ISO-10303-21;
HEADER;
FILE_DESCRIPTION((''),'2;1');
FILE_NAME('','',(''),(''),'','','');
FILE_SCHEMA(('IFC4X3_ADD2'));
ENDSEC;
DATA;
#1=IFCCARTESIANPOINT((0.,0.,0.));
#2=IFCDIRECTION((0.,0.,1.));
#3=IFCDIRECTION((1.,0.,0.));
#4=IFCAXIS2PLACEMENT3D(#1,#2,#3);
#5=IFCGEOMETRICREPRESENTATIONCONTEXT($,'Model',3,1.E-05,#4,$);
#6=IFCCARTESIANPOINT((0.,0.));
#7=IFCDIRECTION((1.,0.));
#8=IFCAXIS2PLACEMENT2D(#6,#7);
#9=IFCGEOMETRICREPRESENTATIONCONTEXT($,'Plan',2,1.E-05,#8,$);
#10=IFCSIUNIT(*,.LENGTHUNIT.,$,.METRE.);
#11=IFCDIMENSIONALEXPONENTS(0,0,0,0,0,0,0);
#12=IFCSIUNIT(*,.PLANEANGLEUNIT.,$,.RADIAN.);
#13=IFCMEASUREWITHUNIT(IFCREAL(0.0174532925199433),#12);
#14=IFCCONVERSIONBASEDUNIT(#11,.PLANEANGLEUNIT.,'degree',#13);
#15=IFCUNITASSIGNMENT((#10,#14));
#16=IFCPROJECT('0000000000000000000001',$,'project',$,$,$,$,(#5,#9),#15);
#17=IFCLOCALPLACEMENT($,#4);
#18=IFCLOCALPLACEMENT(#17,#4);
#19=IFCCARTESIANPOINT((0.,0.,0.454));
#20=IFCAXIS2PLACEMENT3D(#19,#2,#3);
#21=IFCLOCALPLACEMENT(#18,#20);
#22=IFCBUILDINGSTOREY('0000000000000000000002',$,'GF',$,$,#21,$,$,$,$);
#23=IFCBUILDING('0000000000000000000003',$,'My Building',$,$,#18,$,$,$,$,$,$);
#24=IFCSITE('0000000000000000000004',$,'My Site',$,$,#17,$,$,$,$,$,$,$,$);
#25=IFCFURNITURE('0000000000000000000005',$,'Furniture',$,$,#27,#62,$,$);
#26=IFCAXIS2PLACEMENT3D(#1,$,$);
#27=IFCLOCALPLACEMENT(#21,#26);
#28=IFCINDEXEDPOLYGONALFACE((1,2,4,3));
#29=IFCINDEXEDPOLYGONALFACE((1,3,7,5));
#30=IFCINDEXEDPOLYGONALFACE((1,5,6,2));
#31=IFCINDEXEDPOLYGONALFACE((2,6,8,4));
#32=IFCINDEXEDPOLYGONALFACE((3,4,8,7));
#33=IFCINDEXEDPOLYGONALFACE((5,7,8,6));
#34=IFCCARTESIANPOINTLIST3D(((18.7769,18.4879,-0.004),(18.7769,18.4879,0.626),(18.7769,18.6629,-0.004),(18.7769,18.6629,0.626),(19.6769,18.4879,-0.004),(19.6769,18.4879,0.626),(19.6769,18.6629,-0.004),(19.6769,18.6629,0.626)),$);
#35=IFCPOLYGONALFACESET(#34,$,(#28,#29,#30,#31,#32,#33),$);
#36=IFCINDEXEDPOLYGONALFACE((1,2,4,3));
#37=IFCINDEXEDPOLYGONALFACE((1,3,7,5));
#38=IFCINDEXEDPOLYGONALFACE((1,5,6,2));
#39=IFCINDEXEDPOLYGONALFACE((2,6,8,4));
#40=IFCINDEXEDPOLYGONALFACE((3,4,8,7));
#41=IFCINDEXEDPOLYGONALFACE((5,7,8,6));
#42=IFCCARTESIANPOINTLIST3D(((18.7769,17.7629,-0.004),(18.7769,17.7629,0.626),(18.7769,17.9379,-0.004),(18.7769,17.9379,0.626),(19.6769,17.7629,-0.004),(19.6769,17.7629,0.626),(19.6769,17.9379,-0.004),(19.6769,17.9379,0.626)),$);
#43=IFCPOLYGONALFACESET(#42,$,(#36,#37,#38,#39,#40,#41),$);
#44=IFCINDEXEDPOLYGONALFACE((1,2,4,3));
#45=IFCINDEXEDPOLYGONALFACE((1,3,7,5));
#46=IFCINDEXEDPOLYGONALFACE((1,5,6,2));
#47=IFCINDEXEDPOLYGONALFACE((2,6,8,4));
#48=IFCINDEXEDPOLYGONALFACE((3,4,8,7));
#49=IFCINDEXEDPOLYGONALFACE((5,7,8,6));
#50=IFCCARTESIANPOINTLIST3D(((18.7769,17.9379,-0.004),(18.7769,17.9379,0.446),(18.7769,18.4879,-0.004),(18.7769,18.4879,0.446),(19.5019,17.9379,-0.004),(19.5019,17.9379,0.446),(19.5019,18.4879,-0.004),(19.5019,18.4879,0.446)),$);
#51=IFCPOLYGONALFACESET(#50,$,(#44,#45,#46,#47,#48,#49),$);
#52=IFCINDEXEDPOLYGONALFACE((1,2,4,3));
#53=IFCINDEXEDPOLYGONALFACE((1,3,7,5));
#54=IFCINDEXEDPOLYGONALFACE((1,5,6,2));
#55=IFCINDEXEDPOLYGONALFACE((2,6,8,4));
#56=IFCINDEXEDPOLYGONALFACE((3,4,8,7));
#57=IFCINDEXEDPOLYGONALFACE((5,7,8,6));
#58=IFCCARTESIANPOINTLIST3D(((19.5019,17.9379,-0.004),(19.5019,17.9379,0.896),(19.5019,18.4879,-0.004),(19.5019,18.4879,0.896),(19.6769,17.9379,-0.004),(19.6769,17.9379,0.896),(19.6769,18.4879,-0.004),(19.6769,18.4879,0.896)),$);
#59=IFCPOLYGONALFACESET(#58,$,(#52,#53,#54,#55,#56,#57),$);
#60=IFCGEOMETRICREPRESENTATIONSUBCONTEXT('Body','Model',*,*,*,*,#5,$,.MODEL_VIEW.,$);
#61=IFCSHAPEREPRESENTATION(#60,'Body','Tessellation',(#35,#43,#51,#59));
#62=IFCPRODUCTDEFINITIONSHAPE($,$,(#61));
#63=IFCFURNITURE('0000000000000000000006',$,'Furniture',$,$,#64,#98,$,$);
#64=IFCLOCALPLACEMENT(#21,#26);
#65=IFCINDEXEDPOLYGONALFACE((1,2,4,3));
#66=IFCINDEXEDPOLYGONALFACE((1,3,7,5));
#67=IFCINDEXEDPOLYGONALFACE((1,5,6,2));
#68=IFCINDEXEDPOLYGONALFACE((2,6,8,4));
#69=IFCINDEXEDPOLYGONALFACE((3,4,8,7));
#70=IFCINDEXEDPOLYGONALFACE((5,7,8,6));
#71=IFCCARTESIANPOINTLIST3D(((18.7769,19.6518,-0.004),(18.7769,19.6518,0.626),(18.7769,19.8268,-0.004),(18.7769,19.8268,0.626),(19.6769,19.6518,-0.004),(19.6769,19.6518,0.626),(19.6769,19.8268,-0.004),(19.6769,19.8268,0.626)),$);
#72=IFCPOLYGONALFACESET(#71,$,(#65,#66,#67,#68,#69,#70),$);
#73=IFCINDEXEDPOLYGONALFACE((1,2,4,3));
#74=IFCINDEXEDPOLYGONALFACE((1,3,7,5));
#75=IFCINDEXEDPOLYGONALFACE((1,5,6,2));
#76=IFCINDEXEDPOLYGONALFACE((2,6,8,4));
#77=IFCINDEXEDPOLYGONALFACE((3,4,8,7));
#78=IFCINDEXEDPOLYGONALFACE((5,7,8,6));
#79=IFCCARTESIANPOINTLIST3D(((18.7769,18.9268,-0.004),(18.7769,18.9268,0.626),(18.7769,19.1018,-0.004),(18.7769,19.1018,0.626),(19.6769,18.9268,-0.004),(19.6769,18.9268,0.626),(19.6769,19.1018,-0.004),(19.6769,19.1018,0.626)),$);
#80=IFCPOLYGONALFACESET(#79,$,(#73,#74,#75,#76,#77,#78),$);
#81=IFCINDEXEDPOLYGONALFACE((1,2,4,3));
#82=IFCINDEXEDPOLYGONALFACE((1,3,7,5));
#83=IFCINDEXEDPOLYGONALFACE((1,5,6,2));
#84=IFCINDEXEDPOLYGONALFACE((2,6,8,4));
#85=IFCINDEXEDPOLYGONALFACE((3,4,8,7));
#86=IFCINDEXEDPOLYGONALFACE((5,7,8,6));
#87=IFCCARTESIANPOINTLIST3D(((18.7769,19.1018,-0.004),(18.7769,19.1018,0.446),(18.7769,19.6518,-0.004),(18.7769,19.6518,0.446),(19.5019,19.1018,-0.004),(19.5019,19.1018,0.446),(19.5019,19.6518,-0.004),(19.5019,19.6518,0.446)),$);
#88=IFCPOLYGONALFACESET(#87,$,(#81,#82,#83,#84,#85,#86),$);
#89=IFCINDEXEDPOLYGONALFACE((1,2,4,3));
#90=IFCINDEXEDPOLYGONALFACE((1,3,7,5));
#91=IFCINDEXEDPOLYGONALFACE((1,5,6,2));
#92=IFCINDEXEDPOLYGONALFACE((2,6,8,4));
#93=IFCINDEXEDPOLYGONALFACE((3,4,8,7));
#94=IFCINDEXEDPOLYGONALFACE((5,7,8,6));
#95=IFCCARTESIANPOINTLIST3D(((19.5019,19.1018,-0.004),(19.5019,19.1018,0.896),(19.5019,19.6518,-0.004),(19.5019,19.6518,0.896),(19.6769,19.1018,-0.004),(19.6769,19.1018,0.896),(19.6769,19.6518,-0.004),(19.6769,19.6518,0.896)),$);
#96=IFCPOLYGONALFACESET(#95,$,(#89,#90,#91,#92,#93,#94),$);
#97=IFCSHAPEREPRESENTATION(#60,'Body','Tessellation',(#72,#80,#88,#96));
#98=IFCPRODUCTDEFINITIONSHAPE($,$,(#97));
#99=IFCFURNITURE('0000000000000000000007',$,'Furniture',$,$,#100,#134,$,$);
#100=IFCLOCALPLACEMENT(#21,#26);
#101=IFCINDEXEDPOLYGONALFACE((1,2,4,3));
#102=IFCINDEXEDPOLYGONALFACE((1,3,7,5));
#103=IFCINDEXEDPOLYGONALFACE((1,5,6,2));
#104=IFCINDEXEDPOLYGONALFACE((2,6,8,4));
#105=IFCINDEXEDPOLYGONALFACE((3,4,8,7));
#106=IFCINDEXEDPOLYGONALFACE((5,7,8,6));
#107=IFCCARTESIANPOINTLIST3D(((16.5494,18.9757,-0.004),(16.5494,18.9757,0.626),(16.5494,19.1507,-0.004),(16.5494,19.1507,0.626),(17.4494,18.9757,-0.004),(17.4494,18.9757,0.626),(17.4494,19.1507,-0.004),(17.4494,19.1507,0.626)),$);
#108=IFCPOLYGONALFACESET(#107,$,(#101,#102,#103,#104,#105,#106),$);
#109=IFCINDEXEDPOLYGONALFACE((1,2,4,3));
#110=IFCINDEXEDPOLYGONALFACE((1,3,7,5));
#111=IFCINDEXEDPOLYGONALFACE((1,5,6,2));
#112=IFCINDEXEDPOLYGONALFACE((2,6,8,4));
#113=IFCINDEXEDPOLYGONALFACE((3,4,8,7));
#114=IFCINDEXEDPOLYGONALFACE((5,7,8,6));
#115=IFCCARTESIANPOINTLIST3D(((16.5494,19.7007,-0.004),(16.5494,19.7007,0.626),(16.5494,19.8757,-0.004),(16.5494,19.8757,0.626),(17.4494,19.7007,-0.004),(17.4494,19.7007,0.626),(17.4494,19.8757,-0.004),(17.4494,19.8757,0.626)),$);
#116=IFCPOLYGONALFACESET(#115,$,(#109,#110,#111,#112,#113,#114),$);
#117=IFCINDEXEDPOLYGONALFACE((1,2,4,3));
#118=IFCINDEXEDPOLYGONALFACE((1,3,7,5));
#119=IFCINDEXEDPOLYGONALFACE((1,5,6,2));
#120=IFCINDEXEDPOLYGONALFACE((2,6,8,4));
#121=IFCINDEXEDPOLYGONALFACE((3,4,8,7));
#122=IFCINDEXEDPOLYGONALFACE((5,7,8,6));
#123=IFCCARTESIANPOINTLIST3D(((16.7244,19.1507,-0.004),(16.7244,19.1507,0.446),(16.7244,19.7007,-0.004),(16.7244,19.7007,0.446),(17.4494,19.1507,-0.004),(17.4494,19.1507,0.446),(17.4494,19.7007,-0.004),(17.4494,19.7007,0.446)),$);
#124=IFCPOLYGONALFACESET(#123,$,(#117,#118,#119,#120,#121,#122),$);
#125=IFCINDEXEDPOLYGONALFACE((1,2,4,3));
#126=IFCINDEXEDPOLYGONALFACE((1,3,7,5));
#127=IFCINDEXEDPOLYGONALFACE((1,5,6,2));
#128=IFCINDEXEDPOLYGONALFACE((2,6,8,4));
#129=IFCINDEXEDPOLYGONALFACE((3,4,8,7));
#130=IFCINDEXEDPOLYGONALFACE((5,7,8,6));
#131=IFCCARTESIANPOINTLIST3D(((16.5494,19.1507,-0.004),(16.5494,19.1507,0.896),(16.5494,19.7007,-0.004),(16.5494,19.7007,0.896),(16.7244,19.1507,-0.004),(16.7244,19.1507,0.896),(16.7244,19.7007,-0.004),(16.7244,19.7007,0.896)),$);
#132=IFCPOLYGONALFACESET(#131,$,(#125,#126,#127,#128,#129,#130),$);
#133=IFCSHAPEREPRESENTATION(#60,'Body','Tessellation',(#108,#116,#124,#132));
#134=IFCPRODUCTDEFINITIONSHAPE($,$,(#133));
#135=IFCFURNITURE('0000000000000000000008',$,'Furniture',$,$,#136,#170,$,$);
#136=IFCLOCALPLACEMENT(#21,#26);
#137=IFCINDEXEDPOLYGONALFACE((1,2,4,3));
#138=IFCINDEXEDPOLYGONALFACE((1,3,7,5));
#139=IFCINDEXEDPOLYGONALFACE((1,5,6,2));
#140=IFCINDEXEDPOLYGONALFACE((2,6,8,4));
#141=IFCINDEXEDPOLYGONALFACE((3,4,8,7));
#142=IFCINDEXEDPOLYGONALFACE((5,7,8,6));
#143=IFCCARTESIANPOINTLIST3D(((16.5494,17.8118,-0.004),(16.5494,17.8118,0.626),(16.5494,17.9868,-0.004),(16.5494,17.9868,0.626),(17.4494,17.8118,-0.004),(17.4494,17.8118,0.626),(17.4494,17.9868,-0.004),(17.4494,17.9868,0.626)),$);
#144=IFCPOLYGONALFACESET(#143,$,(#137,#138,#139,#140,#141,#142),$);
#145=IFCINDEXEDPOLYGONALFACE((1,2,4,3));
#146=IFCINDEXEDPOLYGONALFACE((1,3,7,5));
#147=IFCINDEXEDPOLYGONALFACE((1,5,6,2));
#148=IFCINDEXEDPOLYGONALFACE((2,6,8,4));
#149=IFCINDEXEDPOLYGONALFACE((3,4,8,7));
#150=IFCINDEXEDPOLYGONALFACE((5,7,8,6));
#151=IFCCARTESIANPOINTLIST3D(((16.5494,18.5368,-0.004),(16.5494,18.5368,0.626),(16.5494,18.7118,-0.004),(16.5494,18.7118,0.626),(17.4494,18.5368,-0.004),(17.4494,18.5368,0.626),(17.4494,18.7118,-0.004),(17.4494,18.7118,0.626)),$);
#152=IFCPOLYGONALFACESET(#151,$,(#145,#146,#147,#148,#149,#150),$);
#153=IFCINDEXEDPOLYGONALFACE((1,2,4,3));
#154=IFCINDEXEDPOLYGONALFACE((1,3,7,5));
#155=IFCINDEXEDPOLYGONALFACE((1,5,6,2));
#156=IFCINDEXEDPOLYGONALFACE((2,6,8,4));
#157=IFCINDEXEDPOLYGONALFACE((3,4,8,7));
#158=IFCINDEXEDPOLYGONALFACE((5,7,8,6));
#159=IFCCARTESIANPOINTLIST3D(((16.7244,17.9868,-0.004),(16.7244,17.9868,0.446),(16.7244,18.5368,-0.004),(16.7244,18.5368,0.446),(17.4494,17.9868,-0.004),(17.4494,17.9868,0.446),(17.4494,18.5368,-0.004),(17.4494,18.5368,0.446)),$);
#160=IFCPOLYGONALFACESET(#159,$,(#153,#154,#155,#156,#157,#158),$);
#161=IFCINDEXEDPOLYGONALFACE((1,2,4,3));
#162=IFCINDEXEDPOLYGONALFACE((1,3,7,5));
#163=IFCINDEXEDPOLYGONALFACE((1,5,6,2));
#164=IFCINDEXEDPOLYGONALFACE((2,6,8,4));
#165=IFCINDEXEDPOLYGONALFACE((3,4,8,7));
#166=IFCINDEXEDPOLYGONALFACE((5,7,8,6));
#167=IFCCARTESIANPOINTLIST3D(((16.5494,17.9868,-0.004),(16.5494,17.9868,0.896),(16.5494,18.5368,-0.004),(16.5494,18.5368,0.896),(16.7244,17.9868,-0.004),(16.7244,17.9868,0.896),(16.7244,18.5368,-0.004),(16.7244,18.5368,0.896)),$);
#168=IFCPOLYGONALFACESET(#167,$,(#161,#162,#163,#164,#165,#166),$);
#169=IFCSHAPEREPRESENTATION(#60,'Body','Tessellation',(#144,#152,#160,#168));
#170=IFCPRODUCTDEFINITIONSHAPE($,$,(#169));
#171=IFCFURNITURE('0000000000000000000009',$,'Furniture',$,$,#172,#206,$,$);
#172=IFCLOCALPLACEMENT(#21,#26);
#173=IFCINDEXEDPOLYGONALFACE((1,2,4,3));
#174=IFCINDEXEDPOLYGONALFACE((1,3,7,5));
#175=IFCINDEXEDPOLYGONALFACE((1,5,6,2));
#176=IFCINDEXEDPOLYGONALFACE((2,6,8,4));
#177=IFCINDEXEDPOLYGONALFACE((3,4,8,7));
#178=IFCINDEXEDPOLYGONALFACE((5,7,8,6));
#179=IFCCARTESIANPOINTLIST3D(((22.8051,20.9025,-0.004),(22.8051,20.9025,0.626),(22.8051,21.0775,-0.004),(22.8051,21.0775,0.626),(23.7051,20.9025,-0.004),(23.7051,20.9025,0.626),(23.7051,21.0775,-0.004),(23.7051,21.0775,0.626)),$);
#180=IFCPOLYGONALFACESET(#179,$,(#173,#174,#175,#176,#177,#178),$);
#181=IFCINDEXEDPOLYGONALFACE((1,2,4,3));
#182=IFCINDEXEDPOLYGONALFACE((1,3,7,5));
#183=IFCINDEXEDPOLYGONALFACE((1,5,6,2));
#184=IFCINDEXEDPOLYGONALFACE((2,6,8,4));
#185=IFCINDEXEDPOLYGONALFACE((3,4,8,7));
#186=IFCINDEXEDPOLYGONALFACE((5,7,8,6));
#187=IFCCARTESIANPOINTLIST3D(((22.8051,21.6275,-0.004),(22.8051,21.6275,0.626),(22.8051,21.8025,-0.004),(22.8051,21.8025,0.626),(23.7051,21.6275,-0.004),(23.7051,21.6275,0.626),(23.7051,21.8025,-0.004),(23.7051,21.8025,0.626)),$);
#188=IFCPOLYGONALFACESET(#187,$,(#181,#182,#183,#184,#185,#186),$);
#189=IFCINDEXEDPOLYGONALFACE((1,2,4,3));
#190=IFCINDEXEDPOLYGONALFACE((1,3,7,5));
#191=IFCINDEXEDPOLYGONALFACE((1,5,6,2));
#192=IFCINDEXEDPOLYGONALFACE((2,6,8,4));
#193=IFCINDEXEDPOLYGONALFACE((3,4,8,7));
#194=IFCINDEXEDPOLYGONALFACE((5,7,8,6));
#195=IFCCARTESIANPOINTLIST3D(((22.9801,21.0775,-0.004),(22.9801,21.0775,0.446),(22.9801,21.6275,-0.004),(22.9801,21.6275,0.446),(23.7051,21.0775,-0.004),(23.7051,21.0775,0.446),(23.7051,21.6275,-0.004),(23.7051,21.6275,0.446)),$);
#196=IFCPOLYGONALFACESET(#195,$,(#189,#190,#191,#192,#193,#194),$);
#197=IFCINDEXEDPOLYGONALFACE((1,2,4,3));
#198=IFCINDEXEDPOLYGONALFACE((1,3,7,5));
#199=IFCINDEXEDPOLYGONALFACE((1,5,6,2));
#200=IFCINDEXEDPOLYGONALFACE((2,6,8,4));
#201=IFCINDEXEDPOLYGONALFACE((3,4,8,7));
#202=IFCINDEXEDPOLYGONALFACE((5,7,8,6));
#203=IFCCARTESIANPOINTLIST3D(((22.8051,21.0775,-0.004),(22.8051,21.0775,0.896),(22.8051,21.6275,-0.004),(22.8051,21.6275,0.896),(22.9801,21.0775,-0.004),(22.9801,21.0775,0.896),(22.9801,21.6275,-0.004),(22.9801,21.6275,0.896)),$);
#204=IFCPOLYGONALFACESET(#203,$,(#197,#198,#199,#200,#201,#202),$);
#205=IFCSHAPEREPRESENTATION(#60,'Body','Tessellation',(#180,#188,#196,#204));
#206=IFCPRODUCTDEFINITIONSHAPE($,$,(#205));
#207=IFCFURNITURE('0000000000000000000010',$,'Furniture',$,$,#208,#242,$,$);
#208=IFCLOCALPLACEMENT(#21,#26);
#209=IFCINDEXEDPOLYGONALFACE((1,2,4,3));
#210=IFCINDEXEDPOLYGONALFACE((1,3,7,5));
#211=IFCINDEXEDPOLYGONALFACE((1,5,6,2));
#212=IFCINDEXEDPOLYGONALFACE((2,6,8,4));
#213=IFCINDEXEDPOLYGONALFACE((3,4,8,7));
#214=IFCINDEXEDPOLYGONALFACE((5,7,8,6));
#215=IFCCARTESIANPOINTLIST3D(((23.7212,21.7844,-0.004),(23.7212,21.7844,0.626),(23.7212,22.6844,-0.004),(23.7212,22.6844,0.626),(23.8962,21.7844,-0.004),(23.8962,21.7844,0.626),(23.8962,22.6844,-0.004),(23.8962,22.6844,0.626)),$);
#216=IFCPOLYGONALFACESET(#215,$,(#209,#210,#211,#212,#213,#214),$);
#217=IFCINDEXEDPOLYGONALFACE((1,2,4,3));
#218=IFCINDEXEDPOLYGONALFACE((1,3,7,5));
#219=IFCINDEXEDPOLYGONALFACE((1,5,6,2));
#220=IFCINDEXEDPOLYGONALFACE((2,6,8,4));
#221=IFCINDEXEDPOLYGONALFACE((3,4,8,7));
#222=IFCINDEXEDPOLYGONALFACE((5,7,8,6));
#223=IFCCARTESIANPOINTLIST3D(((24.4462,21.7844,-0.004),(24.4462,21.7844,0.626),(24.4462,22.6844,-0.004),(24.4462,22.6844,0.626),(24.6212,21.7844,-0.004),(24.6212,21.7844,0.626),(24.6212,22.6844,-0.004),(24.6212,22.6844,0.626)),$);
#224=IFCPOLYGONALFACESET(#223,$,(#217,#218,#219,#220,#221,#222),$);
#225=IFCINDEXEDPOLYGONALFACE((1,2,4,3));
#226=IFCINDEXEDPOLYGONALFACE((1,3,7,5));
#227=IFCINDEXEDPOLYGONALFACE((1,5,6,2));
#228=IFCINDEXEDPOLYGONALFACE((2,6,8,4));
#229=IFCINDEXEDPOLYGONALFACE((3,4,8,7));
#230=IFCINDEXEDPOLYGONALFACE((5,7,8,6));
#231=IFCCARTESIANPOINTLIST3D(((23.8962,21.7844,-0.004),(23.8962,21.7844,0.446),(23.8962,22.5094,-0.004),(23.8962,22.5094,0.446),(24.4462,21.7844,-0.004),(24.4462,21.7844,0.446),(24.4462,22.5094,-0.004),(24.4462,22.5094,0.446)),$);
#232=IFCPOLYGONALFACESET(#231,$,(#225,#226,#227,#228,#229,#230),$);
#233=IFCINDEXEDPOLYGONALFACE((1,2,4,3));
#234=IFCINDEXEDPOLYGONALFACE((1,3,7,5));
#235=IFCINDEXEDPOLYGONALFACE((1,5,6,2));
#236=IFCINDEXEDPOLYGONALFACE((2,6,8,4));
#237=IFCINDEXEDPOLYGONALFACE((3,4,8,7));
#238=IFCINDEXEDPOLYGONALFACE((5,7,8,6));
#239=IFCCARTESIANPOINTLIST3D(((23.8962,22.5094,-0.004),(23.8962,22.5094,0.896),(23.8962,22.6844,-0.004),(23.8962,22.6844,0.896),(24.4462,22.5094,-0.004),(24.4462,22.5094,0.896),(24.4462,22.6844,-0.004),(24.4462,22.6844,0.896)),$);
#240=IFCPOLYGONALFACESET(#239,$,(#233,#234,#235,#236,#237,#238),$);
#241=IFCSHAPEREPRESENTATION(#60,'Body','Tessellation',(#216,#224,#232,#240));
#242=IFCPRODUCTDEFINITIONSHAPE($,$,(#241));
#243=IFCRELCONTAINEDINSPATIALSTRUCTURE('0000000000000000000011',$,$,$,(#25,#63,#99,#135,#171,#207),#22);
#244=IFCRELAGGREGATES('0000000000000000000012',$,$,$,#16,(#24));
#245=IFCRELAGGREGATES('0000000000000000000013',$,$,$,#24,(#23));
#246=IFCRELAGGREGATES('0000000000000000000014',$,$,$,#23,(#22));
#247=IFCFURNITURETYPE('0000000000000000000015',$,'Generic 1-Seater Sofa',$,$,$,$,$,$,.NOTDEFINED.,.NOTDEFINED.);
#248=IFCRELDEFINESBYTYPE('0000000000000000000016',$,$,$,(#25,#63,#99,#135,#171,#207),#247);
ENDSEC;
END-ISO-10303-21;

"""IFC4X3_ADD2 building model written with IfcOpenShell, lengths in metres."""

from ifc_helpers import new_model, entity, si_unit, converted_unit, frame, origin_with_axes, origin_2d_with_axis, place, context, subcontext, project, spatial, line, indexed_curve, outline, extrude, shape, source, transform, mapped, type_object, type_shapes, element, save


model = new_model("IFC4X3_ADD2")

# Units and contexts
model_context = context("Model", 3, precision=1e-05, world=origin_with_axes())
plan_context = context("Plan", 2, precision=1e-05, world=origin_2d_with_axis())
body_context_1 = subcontext(model_context, "Body", "Model", "MODEL_VIEW")
body_context_2 = subcontext(plan_context, "Body", "Plan", "PLAN_VIEW")
ifc_project = project(units=[si_unit("LENGTHUNIT", "METRE"), converted_unit("PLANEANGLEUNIT", "degree", entity("IfcReal", 0.0174532925199433), si_unit("PLANEANGLEUNIT", "RADIAN"), dimensions=[0, 0, 0, 0, 0, 0, 0])], contexts=[model_context, plan_context])

# Site, building, storey
site_placement = place(None, origin_with_axes())
site = spatial("IfcSite", under=ifc_project, at=site_placement, Name="My Site")
building_placement = place(site_placement, origin_with_axes())
building = spatial("IfcBuilding", under=site, at=building_placement, Name="My Building")
storey_placement = place(building_placement, frame((0.0, 0.0, 0.454), z_axis=(0.0, 0.0, 1.0), x_axis=(1.0, 0.0, 0.0)))
storey = spatial("IfcBuildingStorey", under=building, at=storey_placement, Name="GF")

# Furniture
furniture_type_1 = type_object("IfcFurnitureType", Name="Generic 1-Seater Sofa", AssemblyPlace="NOTDEFINED", PredefinedType="NOTDEFINED")
shared_shape_1 = source(origin_with_axes(), body_context_1, "Body", "SweptSolid", [
    extrude(outline(indexed_curve([(0.0, 0.0), (0.175, 0.0), (0.175, 0.9), (0.0, 0.9)], segments=[line(1, 2, 3, 4, 1)])), frame((-0.45, -0.9, 0.0), z_axis=(0.0, 0.0, 1.0), x_axis=(1.0, 0.0, 0.0)), (0.0, 0.0, 1.0), 0.63),
    extrude(outline(indexed_curve([(0.0, 0.0), (0.175, 0.0), (0.175, 0.9), (0.0, 0.9)], segments=[line(1, 2, 3, 4, 1)])), frame((0.275, -0.9, 0.0), z_axis=(0.0, 0.0, 1.0), x_axis=(1.0, 0.0, 0.0)), (0.0, 0.0, 1.0), 0.63),
    extrude(outline(indexed_curve([(0.175, 0.0), (0.725, 0.0), (0.725, 0.725), (0.175, 0.725)], segments=[line(1, 2, 3, 4, 1)])), frame((-0.45, -0.9, 0.0), z_axis=(0.0, 0.0, 1.0), x_axis=(1.0, 0.0, 0.0)), (0.0, 0.0, 1.0), 0.45),
    extrude(outline(indexed_curve([(0.175, 0.725), (0.725, 0.725), (0.725, 0.9), (0.175, 0.9)], segments=[line(1, 2, 3, 4, 1)])), frame((-0.45, -0.9, 0.0), z_axis=(0.0, 0.0, 1.0), x_axis=(1.0, 0.0, 0.0)), (0.0, 0.0, 1.0), 0.9),
])
shared_shape_2 = source(origin_with_axes(), body_context_2, "Body", "Annotation2D", [
    entity("IfcGeometricCurveSet", [entity("IfcIndexedPolyCurve", entity("IfcCartesianPointList2D", [[0.275, -0.175], [0.275, -0.9], [0.45, -0.9], [0.45, 0.0], [0.275, 0.0], [0.275, -0.9], [-0.275, -0.9], [-0.275, 0.0], [-0.275, -0.175], [0.275, -0.175], [0.275, 0.0], [-0.275, 0.0], [-0.45, 0.0], [-0.45, -0.9], [-0.275, -0.9], [-0.275, -0.175]]))]),
])
type_shapes(furniture_type_1, [shared_shape_1, shared_shape_2])
for number, where, z_axis, x_axis, name in (
    (1, (19.6769, 18.2129, -0.004), (0.0, 0.0, 1.0), (0.0, -1.0, 0.0), "Furniture"),
    (2, (19.6769, 19.3768, -0.004), (0.0, 0.0, 1.0), (0.0, -1.0, 0.0), "Furniture"),
    (3, (16.5494, 19.4257, -0.004), (0.0, 0.0, 1.0), (0.0, 1.0, 0.0), "Furniture"),
    (4, (16.5494, 18.2618, -0.004), (0.0, 0.0, 1.0), (0.0, 1.0, 0.0), "Furniture"),
    (5, (22.8051, 21.3525, -0.004), (0.0, 0.0, 1.0), (0.000001, 1.0, 0.0), "Furniture"),
    (6, (24.1712, 22.6844, -0.004), (0.0, 0.0, 1.0), (1.0, -0.000001, 0.0), "Furniture"),
):
    element("IfcFurniture", number, at=place(storey_placement, frame(where, z_axis=z_axis, x_axis=x_axis)), inside=storey, type_object=furniture_type_1, Name=name, shapes=[
        shape(body_context_1, "Body", "MappedRepresentation", [mapped(shared_shape_1, transform((0.0, 0.0, 0.0), x_axis=(1.0, 0.0, 0.0), y_axis=(0.0, 1.0, 0.0), z_axis=(0.0, 0.0, 1.0), scale=1.0))]),
        shape(body_context_2, "Body", "MappedRepresentation", [mapped(shared_shape_2, transform((0.0, 0.0, 0.0), x_axis=(1.0, 0.0, 0.0), y_axis=(0.0, 1.0, 0.0), z_axis=(0.0, 0.0, 1.0), scale=1.0))]),
    ])

save(model, "model.ifc")
